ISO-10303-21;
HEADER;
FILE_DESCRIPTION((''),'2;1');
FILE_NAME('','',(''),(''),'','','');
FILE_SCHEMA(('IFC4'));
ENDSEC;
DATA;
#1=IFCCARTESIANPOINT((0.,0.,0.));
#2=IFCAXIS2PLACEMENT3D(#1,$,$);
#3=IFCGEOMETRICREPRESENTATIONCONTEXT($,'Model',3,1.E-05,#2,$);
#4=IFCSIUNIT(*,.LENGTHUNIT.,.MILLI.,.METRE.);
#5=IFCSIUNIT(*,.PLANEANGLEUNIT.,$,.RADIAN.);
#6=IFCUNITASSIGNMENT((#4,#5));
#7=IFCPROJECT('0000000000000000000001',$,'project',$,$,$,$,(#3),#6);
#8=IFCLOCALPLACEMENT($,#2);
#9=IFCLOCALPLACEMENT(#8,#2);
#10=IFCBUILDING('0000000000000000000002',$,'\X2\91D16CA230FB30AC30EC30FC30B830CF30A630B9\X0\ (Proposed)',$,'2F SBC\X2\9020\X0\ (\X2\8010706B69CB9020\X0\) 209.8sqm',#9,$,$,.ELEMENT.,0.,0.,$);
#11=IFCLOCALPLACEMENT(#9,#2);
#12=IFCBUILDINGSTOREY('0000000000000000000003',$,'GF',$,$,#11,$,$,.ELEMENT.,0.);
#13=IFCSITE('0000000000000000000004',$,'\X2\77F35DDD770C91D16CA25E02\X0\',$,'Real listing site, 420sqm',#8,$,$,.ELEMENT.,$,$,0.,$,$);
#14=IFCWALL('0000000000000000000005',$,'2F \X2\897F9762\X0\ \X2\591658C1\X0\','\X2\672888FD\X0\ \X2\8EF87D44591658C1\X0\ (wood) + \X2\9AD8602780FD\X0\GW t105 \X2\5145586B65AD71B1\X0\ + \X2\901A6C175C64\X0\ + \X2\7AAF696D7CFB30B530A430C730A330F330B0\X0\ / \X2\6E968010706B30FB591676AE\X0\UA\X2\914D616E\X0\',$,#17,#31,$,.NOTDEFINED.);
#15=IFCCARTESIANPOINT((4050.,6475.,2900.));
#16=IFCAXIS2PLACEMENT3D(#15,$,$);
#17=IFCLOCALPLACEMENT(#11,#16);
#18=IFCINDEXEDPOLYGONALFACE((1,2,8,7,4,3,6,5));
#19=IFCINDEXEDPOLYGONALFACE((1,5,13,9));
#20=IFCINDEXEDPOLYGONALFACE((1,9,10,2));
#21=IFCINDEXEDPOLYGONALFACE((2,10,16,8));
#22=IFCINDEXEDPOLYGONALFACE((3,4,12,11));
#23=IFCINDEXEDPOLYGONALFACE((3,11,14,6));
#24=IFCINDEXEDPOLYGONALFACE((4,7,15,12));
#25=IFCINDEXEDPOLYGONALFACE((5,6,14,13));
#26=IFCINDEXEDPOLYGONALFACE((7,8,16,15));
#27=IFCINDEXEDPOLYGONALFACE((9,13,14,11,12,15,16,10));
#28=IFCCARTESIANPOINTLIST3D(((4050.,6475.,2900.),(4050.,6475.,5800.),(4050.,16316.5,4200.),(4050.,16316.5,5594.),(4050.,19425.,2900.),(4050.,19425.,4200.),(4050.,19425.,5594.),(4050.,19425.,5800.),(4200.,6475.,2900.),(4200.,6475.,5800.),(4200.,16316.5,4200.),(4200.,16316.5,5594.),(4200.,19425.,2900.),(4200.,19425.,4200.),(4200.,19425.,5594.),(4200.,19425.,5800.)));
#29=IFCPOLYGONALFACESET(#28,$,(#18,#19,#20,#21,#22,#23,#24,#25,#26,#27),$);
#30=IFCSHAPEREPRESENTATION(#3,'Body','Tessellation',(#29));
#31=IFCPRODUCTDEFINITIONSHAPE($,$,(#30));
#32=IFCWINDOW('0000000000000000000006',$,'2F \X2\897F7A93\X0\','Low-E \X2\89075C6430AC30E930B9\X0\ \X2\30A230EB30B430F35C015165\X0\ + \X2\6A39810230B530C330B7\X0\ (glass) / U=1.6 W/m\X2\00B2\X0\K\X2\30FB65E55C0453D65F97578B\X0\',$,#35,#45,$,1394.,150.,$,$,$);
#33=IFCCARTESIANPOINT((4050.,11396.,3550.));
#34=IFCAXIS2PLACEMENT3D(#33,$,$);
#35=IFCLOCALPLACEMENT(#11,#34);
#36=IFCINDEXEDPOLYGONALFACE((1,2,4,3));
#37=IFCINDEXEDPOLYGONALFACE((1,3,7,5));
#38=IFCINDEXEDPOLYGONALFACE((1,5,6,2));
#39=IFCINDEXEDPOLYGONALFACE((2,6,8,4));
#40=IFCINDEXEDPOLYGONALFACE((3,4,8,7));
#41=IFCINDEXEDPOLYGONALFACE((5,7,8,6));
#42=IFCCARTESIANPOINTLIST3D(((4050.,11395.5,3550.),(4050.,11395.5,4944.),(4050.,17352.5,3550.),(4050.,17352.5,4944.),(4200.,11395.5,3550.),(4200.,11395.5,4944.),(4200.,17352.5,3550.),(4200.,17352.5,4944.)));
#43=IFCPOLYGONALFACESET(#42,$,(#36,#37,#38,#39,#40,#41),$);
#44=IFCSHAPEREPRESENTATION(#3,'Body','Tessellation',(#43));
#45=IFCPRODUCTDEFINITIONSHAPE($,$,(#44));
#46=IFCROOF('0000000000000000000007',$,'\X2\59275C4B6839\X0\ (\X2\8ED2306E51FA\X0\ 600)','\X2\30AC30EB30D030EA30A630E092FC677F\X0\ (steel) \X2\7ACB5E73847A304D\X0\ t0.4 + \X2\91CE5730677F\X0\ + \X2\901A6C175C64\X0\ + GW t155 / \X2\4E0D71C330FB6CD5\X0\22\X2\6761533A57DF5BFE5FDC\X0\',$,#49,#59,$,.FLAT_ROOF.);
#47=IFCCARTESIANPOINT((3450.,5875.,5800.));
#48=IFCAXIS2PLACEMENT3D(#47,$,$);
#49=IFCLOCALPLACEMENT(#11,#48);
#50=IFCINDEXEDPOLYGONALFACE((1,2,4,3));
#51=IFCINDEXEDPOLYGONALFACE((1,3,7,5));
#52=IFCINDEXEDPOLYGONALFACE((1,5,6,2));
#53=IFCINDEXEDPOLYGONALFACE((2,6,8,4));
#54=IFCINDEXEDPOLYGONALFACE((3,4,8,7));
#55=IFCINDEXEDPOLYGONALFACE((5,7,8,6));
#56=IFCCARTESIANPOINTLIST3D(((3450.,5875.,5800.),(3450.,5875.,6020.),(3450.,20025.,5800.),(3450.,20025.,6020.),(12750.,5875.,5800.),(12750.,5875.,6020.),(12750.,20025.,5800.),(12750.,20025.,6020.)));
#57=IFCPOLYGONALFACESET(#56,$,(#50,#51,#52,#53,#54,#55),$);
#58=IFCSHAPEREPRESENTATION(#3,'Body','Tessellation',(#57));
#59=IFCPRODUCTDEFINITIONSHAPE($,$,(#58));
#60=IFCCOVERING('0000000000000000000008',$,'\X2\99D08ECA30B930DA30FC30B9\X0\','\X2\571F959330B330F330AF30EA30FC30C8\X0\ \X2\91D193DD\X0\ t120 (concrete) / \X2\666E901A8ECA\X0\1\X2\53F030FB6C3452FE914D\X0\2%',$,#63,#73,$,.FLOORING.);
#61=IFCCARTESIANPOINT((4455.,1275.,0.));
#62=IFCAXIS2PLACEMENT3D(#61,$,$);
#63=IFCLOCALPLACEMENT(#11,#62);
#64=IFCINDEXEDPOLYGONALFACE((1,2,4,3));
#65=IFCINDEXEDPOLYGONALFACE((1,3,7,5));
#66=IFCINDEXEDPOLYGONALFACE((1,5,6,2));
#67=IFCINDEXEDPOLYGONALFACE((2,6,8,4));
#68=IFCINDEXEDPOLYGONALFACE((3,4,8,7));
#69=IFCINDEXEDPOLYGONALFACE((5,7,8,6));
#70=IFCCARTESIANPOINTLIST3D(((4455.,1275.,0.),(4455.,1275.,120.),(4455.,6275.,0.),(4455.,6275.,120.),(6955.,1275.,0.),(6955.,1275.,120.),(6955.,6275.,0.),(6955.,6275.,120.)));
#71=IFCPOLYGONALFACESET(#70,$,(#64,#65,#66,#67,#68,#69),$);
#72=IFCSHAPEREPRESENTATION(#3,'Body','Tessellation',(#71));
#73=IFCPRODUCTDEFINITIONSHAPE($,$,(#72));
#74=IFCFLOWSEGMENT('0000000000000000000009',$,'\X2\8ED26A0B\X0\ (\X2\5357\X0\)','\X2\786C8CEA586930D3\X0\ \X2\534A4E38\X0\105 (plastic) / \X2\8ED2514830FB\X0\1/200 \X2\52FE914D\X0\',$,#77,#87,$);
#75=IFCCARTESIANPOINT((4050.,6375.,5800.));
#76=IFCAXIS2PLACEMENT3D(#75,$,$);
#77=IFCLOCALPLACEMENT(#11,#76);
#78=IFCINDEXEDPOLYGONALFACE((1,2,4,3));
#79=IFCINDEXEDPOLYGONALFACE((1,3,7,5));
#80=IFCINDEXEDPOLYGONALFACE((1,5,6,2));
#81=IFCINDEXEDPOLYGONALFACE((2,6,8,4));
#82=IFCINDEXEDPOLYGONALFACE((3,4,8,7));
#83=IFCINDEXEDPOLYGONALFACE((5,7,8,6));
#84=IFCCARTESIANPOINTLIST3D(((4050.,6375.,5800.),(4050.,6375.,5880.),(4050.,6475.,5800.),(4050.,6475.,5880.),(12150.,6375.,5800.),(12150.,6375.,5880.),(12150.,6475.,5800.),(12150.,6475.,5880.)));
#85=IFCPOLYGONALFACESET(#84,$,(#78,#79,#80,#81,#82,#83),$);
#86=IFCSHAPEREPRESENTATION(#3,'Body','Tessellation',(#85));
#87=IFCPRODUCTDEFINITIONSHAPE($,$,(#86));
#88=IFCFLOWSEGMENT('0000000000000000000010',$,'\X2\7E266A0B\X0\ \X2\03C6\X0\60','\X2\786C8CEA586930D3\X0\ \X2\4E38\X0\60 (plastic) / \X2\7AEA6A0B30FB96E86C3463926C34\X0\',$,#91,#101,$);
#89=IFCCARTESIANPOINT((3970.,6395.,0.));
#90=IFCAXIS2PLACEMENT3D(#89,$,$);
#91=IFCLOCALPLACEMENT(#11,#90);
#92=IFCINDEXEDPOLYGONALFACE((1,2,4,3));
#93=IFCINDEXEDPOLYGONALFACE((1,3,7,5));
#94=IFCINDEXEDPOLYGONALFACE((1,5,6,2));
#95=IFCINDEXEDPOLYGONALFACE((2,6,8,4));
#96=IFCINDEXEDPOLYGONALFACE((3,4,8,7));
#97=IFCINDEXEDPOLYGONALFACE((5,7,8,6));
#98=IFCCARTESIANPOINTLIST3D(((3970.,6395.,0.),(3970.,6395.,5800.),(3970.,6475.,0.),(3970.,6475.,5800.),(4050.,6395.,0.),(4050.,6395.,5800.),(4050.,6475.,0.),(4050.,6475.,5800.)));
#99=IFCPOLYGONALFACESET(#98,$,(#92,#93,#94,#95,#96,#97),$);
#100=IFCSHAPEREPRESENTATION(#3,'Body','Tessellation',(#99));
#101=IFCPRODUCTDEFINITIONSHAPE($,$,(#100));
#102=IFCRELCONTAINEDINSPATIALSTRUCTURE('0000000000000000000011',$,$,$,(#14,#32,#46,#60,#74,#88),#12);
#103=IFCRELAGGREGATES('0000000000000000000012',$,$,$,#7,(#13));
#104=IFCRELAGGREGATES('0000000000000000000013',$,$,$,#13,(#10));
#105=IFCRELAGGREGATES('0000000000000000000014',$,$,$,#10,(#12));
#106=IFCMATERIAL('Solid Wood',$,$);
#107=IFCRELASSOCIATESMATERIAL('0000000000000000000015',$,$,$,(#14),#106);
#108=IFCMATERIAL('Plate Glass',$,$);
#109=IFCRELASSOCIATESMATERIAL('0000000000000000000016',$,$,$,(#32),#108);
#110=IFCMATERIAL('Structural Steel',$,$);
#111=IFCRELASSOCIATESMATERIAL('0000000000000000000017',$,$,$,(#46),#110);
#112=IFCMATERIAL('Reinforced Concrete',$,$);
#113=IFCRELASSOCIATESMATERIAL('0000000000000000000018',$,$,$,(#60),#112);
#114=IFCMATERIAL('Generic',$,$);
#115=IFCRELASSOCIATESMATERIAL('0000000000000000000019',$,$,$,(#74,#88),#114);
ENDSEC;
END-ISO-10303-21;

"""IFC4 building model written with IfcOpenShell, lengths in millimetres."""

from ifc_helpers import new_model, si_unit, frame, frame_2d, origin, place, context, project, spatial, rectangle, extrude, material, element, fill, save


model = new_model("IFC4")

# Units and contexts
model_context = context("Model", 3, precision=1e-05, world=origin())
ifc_project = project(units=[si_unit("LENGTHUNIT", "METRE", prefix="MILLI"), si_unit("PLANEANGLEUNIT", "RADIAN")], contexts=[model_context])

# Site, building, storey
site_placement = place(None, origin())
site = spatial("IfcSite", under=ifc_project, at=site_placement, Name="石川県金沢市", ObjectType="Real listing site, 420sqm", CompositionType="ELEMENT", RefElevation=0.0)
building_placement = place(site_placement, origin())
building = spatial("IfcBuilding", under=site, at=building_placement, Name="金沢・ガレージハウス (Proposed)", ObjectType="2F SBC造 (耐火構造) 209.8sqm", CompositionType="ELEMENT", ElevationOfRefHeight=0.0, ElevationOfTerrain=0.0)
storey_placement = place(building_placement, origin())
storey = spatial("IfcBuildingStorey", under=building, at=storey_placement, Name="GF", CompositionType="ELEMENT", Elevation=0.0)

# Shared definitions
ifc_material_1 = material(Name="Solid Wood")

# Shared definitions
ifc_material_2 = material(Name="Reinforced Concrete")

# Shared definitions
ifc_material_3 = material(Name="Plate Glass")

# Wall, opening, window
wall_1_placement = place(storey_placement, frame((4050.0, 6475.0, 2900.0)))
wall_1 = element("IfcWall", 1, at=wall_1_placement, inside=storey, material=ifc_material_1, Name="2F 西面 外壁", Description="木製 軸組外壁 (wood) + 高性能GW t105 充填断熱 + 通気層 + 窯業系サイディング / 準耐火・外皮UA配慮", PredefinedType="NOTDEFINED", context=model_context, shape_type="SweptSolid", body=[
    extrude(rectangle(XDim=150.0, YDim=12950.0, at=frame_2d((75.0, 6475.0))), frame((4050.0, 6475.0, 2900.0)), (0.0, 0.0, 1.0), 2900.0),
])
opening_1_placement = place(storey_placement, frame((4050.0, 11396.0, 3550.0)))
opening_1 = element("IfcOpeningElement", 2, at=opening_1_placement, cuts=wall_1, PredefinedType="NOTDEFINED", context=model_context, shape_type="SweptSolid", body=[
    extrude(rectangle(XDim=150.0, YDim=5957.0, at=frame_2d((75.0, 2978.0))), frame((4050.0, 11396.0, 3550.0)), (0.0, 0.0, 1.0), 1394.0),
])
window_1_placement = place(storey_placement, frame((4050.0, 11396.0, 3550.0)))
window_1 = element("IfcWindow", 3, at=window_1_placement, inside=storey, material=ifc_material_3, Name="2F 西窓", Description="Low-E 複層ガラス アルゴン封入 + 樹脂サッシ (glass) / U=1.6 W/m²K・日射取得型", OverallHeight=1394.0, OverallWidth=150.0, context=model_context, shape_type="SweptSolid", body=[
    extrude(rectangle(XDim=150.0, YDim=5957.0, at=frame_2d((75.0, 2978.0))), frame((4050.0, 11396.0, 3550.0)), (0.0, 0.0, 1.0), 1394.0),
])
fill(opening_1, window_1)

# Roof
ifc_material_4 = material(Name="Structural Steel")
roof_placement = place(storey_placement, frame((3450.0, 5875.0, 5800.0)))
element("IfcRoof", 4, at=roof_placement, inside=storey, material=ifc_material_4, Name="大屋根 (軒の出 600)", Description="ガルバリウム鋼板 (steel) 立平葺き t0.4 + 野地板 + 通気層 + GW t155 / 不燃・法22条区域対応", PredefinedType="FLAT_ROOF", context=model_context, shape_type="SweptSolid", body=[
    extrude(rectangle(XDim=9300.0, YDim=14150.0, at=frame_2d((4650.0, 7075.0))), frame((3450.0, 5875.0, 5800.0)), (0.0, 0.0, 1.0), 220.0),
])

# Covering
covering_placement = place(storey_placement, frame((4455.0, 1275.0, 0.0)))
element("IfcCovering", 5, at=covering_placement, inside=storey, material=ifc_material_2, Name="駐車スペース", Description="土間コンクリート 金鏝 t120 (concrete) / 普通車1台・水勾配2%", PredefinedType="FLOORING", context=model_context, shape_type="SweptSolid", body=[
    extrude(rectangle(XDim=2500.0, YDim=5000.0, at=frame_2d((1250.0, 2500.0))), frame((4455.0, 1275.0, 0.0)), (0.0, 0.0, 1.0), 120.0),
])

# Flow segments
ifc_material_5 = material(Name="Generic")
flow_segment_1_placement = place(storey_placement, frame((4050.0, 6375.0, 5800.0)))
element("IfcFlowSegment", 6, at=flow_segment_1_placement, inside=storey, material=ifc_material_5, Name="軒樋 (南)", Description="硬質塩ビ 半丸105 (plastic) / 軒先・1/200 勾配", context=model_context, shape_type="SweptSolid", body=[
    extrude(rectangle(XDim=8100.0, YDim=100.0, at=frame_2d((4050.0, 50.0))), frame((4050.0, 6375.0, 5800.0)), (0.0, 0.0, 1.0), 80.0),
])
flow_segment_2_placement = place(storey_placement, frame((3970.0, 6395.0, 0.0)))
element("IfcFlowSegment", 7, at=flow_segment_2_placement, inside=storey, material=ifc_material_5, Name="縦樋 φ60", Description="硬質塩ビ 丸60 (plastic) / 竪樋・雨水排水", context=model_context, shape_type="SweptSolid", body=[
    extrude(rectangle(XDim=80.0, YDim=80.0, at=frame_2d((40.0, 40.0))), frame((3970.0, 6395.0, 0.0)), (0.0, 0.0, 1.0), 5800.0),
])

save(model, "model.ifc")
